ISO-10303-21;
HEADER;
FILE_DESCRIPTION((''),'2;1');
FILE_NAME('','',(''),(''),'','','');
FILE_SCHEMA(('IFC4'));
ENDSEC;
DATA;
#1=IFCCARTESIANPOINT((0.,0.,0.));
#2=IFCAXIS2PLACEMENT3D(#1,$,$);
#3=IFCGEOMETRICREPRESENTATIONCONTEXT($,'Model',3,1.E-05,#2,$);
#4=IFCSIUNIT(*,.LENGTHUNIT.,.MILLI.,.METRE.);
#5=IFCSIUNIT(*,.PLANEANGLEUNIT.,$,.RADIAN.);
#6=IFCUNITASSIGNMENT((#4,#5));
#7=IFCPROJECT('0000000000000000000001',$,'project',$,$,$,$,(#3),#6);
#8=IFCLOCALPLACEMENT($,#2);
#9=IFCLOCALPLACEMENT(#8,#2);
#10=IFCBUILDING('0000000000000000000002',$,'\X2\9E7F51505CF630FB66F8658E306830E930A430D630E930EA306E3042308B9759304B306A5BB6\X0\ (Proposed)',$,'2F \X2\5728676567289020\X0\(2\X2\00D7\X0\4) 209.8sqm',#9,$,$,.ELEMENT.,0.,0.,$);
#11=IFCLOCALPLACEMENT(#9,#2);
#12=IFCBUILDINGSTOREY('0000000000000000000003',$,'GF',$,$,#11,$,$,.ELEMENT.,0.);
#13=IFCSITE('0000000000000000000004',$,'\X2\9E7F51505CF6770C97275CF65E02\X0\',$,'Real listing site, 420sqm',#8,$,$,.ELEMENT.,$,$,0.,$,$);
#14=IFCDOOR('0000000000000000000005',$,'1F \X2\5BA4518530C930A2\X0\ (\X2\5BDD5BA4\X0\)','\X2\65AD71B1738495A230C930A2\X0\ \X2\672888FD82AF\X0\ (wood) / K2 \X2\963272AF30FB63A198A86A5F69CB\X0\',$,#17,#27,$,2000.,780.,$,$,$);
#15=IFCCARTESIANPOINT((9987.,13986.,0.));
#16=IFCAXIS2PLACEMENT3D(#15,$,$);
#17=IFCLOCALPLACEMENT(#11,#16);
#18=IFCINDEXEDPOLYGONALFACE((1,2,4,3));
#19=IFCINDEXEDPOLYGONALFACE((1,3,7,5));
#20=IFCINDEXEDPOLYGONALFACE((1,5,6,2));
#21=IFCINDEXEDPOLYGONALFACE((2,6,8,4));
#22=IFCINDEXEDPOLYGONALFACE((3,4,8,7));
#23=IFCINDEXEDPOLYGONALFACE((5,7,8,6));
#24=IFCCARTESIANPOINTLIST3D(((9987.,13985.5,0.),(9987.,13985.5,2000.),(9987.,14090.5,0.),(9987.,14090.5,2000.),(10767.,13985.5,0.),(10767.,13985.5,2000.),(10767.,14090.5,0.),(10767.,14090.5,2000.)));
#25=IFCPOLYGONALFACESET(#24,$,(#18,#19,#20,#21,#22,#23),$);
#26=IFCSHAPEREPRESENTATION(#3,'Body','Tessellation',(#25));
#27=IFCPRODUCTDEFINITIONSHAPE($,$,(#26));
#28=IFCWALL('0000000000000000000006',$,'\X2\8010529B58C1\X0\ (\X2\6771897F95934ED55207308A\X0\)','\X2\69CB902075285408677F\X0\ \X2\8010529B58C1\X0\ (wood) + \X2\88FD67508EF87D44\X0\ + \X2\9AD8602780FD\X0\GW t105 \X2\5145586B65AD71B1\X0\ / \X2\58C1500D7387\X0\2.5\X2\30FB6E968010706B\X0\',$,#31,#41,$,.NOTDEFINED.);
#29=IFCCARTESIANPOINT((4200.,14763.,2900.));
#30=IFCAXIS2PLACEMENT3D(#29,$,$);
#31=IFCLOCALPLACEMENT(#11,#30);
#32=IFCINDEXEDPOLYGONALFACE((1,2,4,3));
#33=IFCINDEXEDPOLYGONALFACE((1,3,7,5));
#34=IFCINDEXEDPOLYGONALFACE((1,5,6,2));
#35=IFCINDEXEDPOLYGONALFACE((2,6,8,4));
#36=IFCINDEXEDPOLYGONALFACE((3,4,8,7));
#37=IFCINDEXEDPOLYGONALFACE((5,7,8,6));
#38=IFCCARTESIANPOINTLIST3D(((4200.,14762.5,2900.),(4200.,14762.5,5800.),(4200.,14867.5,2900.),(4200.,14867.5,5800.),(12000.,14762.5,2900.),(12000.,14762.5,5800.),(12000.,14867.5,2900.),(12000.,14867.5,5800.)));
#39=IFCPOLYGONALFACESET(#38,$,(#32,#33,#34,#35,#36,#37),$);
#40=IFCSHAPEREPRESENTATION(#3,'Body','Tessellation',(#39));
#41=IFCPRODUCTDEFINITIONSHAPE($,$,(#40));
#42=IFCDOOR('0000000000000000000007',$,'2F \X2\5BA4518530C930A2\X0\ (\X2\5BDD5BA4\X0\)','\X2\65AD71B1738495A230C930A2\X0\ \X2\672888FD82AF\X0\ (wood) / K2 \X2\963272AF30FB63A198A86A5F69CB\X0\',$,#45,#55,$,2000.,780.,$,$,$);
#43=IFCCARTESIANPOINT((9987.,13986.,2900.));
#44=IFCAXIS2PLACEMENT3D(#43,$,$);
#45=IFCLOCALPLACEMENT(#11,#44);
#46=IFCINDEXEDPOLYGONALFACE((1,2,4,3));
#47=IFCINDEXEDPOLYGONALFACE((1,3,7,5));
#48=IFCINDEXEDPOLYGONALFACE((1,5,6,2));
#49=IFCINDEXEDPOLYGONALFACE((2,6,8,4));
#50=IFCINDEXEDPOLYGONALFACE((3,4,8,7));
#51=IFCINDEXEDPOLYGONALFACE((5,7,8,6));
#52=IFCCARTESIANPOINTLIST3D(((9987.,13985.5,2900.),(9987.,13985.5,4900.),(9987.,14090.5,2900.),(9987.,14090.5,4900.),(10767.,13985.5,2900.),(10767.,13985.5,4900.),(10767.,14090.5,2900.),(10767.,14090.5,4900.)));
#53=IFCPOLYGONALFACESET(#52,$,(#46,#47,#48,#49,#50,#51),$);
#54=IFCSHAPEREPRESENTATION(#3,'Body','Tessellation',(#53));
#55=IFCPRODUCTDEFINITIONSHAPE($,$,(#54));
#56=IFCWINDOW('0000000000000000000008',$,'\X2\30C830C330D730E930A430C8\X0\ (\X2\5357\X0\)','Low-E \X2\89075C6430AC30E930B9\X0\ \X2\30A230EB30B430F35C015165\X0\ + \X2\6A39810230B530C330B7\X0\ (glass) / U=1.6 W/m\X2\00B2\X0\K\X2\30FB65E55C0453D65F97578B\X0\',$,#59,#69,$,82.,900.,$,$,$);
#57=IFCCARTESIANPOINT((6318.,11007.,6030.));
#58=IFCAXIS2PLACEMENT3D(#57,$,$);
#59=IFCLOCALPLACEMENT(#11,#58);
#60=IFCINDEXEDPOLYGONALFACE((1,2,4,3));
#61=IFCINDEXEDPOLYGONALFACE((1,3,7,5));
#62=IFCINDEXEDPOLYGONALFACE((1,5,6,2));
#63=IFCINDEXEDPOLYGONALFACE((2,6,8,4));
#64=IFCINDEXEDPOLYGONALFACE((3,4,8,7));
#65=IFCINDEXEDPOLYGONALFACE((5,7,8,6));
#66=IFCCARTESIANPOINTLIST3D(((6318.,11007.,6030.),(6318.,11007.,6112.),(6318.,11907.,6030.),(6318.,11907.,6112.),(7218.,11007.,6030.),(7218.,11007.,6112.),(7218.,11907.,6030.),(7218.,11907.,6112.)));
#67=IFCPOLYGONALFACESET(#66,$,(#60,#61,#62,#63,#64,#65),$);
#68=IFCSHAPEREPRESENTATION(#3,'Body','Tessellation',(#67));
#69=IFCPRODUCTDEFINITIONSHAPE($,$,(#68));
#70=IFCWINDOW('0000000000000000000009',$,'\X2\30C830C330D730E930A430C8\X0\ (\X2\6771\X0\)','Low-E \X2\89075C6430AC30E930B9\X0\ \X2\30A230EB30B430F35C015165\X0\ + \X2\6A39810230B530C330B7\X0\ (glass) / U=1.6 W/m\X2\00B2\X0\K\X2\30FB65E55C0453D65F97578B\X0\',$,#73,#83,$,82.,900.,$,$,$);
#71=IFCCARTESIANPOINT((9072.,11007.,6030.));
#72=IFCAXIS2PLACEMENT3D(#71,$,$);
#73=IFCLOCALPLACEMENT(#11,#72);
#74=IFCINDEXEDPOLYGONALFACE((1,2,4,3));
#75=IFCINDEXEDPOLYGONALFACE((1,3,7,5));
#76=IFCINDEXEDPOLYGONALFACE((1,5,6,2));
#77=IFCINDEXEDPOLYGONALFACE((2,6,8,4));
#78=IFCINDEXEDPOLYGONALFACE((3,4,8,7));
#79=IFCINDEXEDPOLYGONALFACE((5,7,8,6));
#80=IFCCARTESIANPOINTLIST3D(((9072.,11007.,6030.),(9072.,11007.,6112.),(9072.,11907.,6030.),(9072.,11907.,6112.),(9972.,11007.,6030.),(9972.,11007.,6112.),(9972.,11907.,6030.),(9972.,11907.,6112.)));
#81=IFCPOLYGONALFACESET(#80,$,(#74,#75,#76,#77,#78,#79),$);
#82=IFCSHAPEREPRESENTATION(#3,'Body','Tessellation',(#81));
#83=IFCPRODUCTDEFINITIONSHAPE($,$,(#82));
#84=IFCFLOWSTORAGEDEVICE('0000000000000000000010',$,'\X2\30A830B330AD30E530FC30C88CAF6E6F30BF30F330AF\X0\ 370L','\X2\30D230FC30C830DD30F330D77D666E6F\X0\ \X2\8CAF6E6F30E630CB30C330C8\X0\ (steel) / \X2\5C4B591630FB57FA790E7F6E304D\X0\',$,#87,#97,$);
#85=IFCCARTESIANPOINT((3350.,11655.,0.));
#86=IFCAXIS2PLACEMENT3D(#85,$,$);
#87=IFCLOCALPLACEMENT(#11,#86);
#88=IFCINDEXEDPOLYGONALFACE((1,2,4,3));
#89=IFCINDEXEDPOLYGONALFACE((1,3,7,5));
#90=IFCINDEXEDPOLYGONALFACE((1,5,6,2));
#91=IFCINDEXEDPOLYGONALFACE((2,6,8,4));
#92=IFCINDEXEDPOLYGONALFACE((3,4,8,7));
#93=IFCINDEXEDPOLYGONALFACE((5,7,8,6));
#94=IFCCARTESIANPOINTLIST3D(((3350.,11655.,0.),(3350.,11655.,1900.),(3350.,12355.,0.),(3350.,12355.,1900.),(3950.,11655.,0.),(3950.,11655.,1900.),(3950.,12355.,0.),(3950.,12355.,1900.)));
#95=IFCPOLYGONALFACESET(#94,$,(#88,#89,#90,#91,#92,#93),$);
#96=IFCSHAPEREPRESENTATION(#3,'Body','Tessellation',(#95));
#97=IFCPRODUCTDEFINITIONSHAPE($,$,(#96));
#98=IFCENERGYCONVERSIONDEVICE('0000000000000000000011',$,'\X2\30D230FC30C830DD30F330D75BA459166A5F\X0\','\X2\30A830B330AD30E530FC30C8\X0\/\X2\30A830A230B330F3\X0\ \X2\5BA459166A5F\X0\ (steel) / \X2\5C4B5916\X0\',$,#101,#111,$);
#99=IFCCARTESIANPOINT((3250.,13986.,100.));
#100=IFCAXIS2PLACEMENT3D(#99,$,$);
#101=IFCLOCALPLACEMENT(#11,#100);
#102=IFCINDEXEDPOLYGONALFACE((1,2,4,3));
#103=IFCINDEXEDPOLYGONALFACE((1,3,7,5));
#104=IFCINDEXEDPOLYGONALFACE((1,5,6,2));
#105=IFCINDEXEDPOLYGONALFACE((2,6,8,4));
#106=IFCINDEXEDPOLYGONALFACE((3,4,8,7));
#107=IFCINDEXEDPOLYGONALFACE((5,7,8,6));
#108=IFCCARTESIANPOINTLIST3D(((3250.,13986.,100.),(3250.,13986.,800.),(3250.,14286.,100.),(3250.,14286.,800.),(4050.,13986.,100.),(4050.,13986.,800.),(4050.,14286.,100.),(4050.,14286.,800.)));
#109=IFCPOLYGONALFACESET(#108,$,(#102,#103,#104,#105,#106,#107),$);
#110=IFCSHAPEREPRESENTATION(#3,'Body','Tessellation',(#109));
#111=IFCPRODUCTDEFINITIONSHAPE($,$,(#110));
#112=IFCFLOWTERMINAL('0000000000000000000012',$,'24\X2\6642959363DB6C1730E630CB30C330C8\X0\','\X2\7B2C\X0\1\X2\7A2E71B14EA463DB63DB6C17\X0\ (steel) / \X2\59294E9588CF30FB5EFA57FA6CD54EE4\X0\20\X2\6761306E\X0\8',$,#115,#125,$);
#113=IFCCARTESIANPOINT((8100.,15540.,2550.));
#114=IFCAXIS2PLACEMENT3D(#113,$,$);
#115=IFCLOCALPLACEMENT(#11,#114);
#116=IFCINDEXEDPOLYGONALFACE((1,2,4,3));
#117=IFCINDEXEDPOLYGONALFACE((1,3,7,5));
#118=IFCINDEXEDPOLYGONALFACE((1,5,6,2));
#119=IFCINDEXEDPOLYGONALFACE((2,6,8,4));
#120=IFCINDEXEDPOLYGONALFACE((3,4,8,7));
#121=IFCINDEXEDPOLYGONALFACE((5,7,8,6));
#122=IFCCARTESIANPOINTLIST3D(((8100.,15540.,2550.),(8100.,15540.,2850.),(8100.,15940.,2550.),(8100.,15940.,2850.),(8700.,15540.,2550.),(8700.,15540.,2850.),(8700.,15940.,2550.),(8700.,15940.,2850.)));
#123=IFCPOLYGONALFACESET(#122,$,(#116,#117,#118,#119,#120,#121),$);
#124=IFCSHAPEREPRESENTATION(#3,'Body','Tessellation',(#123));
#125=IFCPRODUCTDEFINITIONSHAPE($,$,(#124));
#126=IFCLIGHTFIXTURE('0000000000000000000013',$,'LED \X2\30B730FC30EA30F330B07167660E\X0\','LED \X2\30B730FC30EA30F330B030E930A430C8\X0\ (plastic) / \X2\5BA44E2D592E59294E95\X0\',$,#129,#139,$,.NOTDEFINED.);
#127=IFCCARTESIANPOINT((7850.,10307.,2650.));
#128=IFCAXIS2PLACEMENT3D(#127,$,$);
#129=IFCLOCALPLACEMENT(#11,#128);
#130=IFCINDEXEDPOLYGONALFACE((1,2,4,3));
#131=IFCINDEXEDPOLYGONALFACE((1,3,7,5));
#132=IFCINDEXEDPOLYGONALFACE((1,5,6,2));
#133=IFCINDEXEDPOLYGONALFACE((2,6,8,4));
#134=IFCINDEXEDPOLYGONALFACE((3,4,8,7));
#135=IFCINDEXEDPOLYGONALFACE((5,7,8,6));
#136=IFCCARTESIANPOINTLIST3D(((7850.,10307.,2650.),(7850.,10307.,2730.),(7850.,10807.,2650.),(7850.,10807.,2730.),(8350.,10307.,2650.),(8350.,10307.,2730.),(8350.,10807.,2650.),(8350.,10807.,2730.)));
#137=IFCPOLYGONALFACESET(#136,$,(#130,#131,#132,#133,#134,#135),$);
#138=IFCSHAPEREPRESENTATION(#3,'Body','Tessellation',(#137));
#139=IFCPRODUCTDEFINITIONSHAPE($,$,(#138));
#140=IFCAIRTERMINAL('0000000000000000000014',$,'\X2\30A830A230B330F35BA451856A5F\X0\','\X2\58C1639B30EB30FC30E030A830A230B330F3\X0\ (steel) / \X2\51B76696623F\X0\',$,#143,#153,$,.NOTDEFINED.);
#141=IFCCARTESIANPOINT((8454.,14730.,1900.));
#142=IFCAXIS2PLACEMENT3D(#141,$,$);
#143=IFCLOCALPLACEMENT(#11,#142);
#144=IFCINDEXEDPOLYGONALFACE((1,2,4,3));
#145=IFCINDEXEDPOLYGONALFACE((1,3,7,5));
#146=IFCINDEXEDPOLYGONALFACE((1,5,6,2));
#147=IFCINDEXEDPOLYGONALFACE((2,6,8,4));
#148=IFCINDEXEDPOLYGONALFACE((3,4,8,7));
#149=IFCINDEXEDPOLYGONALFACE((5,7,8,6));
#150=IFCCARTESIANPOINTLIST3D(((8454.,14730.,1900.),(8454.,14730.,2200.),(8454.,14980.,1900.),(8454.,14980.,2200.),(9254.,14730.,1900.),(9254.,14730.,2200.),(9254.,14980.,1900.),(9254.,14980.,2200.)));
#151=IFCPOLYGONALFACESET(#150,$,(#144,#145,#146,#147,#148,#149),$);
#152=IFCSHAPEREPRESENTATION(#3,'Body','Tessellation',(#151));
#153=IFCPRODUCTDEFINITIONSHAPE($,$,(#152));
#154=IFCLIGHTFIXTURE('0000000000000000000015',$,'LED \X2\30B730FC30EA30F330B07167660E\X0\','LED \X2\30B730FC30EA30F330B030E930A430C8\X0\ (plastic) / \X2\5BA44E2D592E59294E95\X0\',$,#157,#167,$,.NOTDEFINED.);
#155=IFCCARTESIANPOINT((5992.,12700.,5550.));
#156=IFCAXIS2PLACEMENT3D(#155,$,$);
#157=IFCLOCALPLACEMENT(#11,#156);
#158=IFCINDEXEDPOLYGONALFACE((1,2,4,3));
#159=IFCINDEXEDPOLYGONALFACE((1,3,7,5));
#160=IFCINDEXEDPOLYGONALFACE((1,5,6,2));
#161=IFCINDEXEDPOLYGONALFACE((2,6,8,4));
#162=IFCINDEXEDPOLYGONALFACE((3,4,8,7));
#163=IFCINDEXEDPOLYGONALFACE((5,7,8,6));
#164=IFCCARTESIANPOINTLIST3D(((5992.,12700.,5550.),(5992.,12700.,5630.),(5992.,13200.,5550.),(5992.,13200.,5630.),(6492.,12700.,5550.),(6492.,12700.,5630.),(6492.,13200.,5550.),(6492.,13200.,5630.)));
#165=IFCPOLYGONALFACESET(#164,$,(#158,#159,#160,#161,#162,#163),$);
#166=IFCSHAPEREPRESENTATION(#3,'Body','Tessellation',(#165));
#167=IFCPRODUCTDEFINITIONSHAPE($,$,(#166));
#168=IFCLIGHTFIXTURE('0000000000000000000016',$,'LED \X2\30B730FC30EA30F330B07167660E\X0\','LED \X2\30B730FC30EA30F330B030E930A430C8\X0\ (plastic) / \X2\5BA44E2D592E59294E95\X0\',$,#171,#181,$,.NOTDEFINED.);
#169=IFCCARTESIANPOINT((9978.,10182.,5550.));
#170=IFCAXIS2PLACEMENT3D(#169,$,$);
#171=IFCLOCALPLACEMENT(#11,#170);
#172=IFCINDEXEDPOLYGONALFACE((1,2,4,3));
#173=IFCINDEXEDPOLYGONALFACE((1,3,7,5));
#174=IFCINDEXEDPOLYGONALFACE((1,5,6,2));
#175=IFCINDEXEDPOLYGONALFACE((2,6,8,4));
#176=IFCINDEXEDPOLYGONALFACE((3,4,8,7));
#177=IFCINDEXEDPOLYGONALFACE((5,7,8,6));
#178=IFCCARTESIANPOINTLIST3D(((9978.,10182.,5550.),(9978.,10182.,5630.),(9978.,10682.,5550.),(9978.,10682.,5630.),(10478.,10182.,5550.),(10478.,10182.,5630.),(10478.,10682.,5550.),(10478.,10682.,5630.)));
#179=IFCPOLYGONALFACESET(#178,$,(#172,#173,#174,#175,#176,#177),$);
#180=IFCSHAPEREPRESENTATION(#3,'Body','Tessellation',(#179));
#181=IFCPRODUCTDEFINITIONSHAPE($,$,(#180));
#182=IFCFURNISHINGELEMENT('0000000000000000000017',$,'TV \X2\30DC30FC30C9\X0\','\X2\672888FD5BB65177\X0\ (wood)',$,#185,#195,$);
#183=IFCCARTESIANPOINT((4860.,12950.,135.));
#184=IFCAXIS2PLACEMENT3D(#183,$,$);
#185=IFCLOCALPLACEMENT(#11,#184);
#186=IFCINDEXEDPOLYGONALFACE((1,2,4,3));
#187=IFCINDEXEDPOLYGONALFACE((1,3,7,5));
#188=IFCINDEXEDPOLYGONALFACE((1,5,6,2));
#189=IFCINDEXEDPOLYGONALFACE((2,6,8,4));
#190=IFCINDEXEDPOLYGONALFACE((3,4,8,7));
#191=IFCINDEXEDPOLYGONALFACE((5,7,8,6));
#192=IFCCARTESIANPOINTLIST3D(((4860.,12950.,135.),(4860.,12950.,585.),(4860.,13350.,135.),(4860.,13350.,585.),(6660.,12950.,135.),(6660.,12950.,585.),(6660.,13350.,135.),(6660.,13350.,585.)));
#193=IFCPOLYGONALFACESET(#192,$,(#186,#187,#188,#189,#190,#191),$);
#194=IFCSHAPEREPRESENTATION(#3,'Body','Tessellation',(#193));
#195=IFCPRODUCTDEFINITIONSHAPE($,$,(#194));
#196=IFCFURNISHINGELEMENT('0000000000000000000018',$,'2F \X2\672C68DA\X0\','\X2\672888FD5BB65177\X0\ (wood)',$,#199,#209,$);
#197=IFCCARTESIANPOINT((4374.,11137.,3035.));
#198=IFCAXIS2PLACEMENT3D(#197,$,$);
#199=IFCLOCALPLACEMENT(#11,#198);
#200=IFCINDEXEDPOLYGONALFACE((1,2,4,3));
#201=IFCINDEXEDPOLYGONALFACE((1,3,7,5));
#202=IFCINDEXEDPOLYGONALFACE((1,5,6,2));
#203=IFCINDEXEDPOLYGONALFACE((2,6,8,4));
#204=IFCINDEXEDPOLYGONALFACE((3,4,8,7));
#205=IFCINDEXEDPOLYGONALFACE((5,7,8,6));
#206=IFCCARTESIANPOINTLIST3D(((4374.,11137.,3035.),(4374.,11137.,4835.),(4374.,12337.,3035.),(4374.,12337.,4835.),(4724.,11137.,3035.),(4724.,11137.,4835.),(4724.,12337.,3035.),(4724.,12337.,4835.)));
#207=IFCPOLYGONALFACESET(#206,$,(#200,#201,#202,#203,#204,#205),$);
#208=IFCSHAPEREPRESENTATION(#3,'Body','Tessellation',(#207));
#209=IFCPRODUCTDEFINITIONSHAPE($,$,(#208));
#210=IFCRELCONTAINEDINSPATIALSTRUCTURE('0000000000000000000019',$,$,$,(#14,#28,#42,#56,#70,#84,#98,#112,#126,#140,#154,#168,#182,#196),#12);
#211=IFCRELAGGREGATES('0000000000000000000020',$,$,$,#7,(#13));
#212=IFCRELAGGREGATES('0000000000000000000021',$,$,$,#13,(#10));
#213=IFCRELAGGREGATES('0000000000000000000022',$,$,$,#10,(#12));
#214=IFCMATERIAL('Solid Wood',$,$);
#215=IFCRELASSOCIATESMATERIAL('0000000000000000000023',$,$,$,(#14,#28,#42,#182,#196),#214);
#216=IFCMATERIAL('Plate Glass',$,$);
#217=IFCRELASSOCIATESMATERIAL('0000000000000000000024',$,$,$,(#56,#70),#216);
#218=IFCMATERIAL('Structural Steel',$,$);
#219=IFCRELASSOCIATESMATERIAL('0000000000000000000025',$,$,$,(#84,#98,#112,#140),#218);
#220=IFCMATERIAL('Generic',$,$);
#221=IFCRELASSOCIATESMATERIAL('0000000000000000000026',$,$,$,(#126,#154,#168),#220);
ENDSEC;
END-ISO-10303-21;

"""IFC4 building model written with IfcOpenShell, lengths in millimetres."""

from ifc_helpers import new_model, si_unit, frame, frame_2d, origin, place, context, project, spatial, rectangle, extrude, material, element, save


model = new_model("IFC4")

# Units and contexts
model_context = context("Model", 3, precision=1e-05, world=origin())
ifc_project = project(units=[si_unit("LENGTHUNIT", "METRE", prefix="MILLI"), si_unit("PLANEANGLEUNIT", "RADIAN")], contexts=[model_context])

# Site, building, storey
site_placement = place(None, origin())
site = spatial("IfcSite", under=ifc_project, at=site_placement, Name="鹿児島県霧島市", ObjectType="Real listing site, 420sqm", CompositionType="ELEMENT", RefElevation=0.0)
building_placement = place(site_placement, origin())
building = spatial("IfcBuilding", under=site, at=building_placement, Name="鹿児島・書斎とライブラリのある静かな家 (Proposed)", ObjectType="2F 在来木造(2×4) 209.8sqm", CompositionType="ELEMENT", ElevationOfRefHeight=0.0, ElevationOfTerrain=0.0)
storey_placement = place(building_placement, origin())
storey = spatial("IfcBuildingStorey", under=building, at=storey_placement, Name="GF", CompositionType="ELEMENT", Elevation=0.0)

# Shared definitions
ifc_material_1 = material(Name="Solid Wood")

# Door
door_1_placement = place(storey_placement, frame((9987.0, 13986.0, 0.0)))
element("IfcDoor", 1, at=door_1_placement, inside=storey, material=ifc_material_1, Name="1F 室内ドア (寝室)", Description="断熱玄関ドア 木製芯 (wood) / K2 防犯・採風機構", OverallHeight=2000.0, OverallWidth=780.0, context=model_context, shape_type="SweptSolid", body=[
    extrude(rectangle(XDim=780.0, YDim=105.0, at=frame_2d((390.0, 52.0))), frame((9987.0, 13986.0, 0.0)), (0.0, 0.0, 1.0), 2000.0),
])

# Wall
wall_1_placement = place(storey_placement, frame((4200.0, 14763.0, 2900.0)))
element("IfcWall", 2, at=wall_1_placement, inside=storey, material=ifc_material_1, Name="耐力壁 (東西間仕切り)", Description="構造用合板 耐力壁 (wood) + 製材軸組 + 高性能GW t105 充填断熱 / 壁倍率2.5・準耐火", PredefinedType="NOTDEFINED", context=model_context, shape_type="SweptSolid", body=[
    extrude(rectangle(XDim=7800.0, YDim=105.0, at=frame_2d((3900.0, 52.0))), frame((4200.0, 14763.0, 2900.0)), (0.0, 0.0, 1.0), 2900.0),
])

# Door
door_2_placement = place(storey_placement, frame((9987.0, 13986.0, 2900.0)))
element("IfcDoor", 3, at=door_2_placement, inside=storey, material=ifc_material_1, Name="2F 室内ドア (寝室)", Description="断熱玄関ドア 木製芯 (wood) / K2 防犯・採風機構", OverallHeight=2000.0, OverallWidth=780.0, context=model_context, shape_type="SweptSolid", body=[
    extrude(rectangle(XDim=780.0, YDim=105.0, at=frame_2d((390.0, 52.0))), frame((9987.0, 13986.0, 2900.0)), (0.0, 0.0, 1.0), 2000.0),
])

# Windows
ifc_material_2 = material(Name="Plate Glass")
window_1_placement = place(storey_placement, frame((6318.0, 11007.0, 6030.0)))
element("IfcWindow", 4, at=window_1_placement, inside=storey, material=ifc_material_2, Name="トップライト (南)", Description="Low-E 複層ガラス アルゴン封入 + 樹脂サッシ (glass) / U=1.6 W/m²K・日射取得型", OverallHeight=82.0, OverallWidth=900.0, context=model_context, shape_type="SweptSolid", body=[
    extrude(rectangle(XDim=900.0, YDim=900.0, at=frame_2d((450.0, 450.0))), frame((6318.0, 11007.0, 6030.0)), (0.0, 0.0, 1.0), 82.0),
])
window_2_placement = place(storey_placement, frame((9072.0, 11007.0, 6030.0)))
element("IfcWindow", 5, at=window_2_placement, inside=storey, material=ifc_material_2, Name="トップライト (東)", Description="Low-E 複層ガラス アルゴン封入 + 樹脂サッシ (glass) / U=1.6 W/m²K・日射取得型", OverallHeight=82.0, OverallWidth=900.0, context=model_context, shape_type="SweptSolid", body=[
    extrude(rectangle(XDim=900.0, YDim=900.0, at=frame_2d((450.0, 450.0))), frame((9072.0, 11007.0, 6030.0)), (0.0, 0.0, 1.0), 82.0),
])

# Flow storage device
ifc_material_3 = material(Name="Structural Steel")
flow_storage_device_placement = place(storey_placement, frame((3350.0, 11655.0, 0.0)))
element("IfcFlowStorageDevice", 6, at=flow_storage_device_placement, inside=storey, material=ifc_material_3, Name="エコキュート貯湯タンク 370L", Description="ヒートポンプ給湯 貯湯ユニット (steel) / 屋外・基礎置き", context=model_context, shape_type="SweptSolid", body=[
    extrude(rectangle(XDim=600.0, YDim=700.0, at=frame_2d((300.0, 350.0))), frame((3350.0, 11655.0, 0.0)), (0.0, 0.0, 1.0), 1900.0),
])

# Energy conversion device
energy_conversion_device_placement = place(storey_placement, frame((3250.0, 13986.0, 100.0)))
element("IfcEnergyConversionDevice", 7, at=energy_conversion_device_placement, inside=storey, material=ifc_material_3, Name="ヒートポンプ室外機", Description="エコキュート/エアコン 室外機 (steel) / 屋外", context=model_context, shape_type="SweptSolid", body=[
    extrude(rectangle(XDim=800.0, YDim=300.0, at=frame_2d((400.0, 150.0))), frame((3250.0, 13986.0, 100.0)), (0.0, 0.0, 1.0), 700.0),
])

# Flow terminal
flow_terminal_placement = place(storey_placement, frame((8100.0, 15540.0, 2550.0)))
element("IfcFlowTerminal", 8, at=flow_terminal_placement, inside=storey, material=ifc_material_3, Name="24時間換気ユニット", Description="第1種熱交換換気 (steel) / 天井裏・建基法令20条の8", context=model_context, shape_type="SweptSolid", body=[
    extrude(rectangle(XDim=600.0, YDim=400.0, at=frame_2d((300.0, 200.0))), frame((8100.0, 15540.0, 2550.0)), (0.0, 0.0, 1.0), 300.0),
])

# Light fixture
ifc_material_4 = material(Name="Generic")
light_fixture_1_placement = place(storey_placement, frame((7850.0, 10307.0, 2650.0)))
element("IfcLightFixture", 9, at=light_fixture_1_placement, inside=storey, material=ifc_material_4, Name="LED シーリング照明", Description="LED シーリングライト (plastic) / 室中央天井", PredefinedType="NOTDEFINED", context=model_context, shape_type="SweptSolid", body=[
    extrude(rectangle(XDim=500.0, YDim=500.0, at=frame_2d((250.0, 250.0))), frame((7850.0, 10307.0, 2650.0)), (0.0, 0.0, 1.0), 80.0),
])

# Air terminal
air_terminal_placement = place(storey_placement, frame((8454.0, 14730.0, 1900.0)))
element("IfcAirTerminal", 10, at=air_terminal_placement, inside=storey, material=ifc_material_3, Name="エアコン室内機", Description="壁掛ルームエアコン (steel) / 冷暖房", PredefinedType="NOTDEFINED", context=model_context, shape_type="SweptSolid", body=[
    extrude(rectangle(XDim=800.0, YDim=250.0, at=frame_2d((400.0, 125.0))), frame((8454.0, 14730.0, 1900.0)), (0.0, 0.0, 1.0), 300.0),
])

# Light fixtures
light_fixture_2_placement = place(storey_placement, frame((5992.0, 12700.0, 5550.0)))
element("IfcLightFixture", 11, at=light_fixture_2_placement, inside=storey, material=ifc_material_4, Name="LED シーリング照明", Description="LED シーリングライト (plastic) / 室中央天井", PredefinedType="NOTDEFINED", context=model_context, shape_type="SweptSolid", body=[
    extrude(rectangle(XDim=500.0, YDim=500.0, at=frame_2d((250.0, 250.0))), frame((5992.0, 12700.0, 5550.0)), (0.0, 0.0, 1.0), 80.0),
])
light_fixture_3_placement = place(storey_placement, frame((9978.0, 10182.0, 5550.0)))
element("IfcLightFixture", 12, at=light_fixture_3_placement, inside=storey, material=ifc_material_4, Name="LED シーリング照明", Description="LED シーリングライト (plastic) / 室中央天井", PredefinedType="NOTDEFINED", context=model_context, shape_type="SweptSolid", body=[
    extrude(rectangle(XDim=500.0, YDim=500.0, at=frame_2d((250.0, 250.0))), frame((9978.0, 10182.0, 5550.0)), (0.0, 0.0, 1.0), 80.0),
])

# Furnishing elements
furnishing_1_placement = place(storey_placement, frame((4860.0, 12950.0, 135.0)))
element("IfcFurnishingElement", 13, at=furnishing_1_placement, inside=storey, material=ifc_material_1, Name="TV ボード", Description="木製家具 (wood)", context=model_context, shape_type="SweptSolid", body=[
    extrude(rectangle(XDim=1800.0, YDim=400.0, at=frame_2d((900.0, 200.0))), frame((4860.0, 12950.0, 135.0)), (0.0, 0.0, 1.0), 450.0),
])
furnishing_2_placement = place(storey_placement, frame((4374.0, 11137.0, 3035.0)))
element("IfcFurnishingElement", 14, at=furnishing_2_placement, inside=storey, material=ifc_material_1, Name="2F 本棚", Description="木製家具 (wood)", context=model_context, shape_type="SweptSolid", body=[
    extrude(rectangle(XDim=350.0, YDim=1200.0, at=frame_2d((175.0, 600.0))), frame((4374.0, 11137.0, 3035.0)), (0.0, 0.0, 1.0), 1800.0),
])

save(model, "model.ifc")
